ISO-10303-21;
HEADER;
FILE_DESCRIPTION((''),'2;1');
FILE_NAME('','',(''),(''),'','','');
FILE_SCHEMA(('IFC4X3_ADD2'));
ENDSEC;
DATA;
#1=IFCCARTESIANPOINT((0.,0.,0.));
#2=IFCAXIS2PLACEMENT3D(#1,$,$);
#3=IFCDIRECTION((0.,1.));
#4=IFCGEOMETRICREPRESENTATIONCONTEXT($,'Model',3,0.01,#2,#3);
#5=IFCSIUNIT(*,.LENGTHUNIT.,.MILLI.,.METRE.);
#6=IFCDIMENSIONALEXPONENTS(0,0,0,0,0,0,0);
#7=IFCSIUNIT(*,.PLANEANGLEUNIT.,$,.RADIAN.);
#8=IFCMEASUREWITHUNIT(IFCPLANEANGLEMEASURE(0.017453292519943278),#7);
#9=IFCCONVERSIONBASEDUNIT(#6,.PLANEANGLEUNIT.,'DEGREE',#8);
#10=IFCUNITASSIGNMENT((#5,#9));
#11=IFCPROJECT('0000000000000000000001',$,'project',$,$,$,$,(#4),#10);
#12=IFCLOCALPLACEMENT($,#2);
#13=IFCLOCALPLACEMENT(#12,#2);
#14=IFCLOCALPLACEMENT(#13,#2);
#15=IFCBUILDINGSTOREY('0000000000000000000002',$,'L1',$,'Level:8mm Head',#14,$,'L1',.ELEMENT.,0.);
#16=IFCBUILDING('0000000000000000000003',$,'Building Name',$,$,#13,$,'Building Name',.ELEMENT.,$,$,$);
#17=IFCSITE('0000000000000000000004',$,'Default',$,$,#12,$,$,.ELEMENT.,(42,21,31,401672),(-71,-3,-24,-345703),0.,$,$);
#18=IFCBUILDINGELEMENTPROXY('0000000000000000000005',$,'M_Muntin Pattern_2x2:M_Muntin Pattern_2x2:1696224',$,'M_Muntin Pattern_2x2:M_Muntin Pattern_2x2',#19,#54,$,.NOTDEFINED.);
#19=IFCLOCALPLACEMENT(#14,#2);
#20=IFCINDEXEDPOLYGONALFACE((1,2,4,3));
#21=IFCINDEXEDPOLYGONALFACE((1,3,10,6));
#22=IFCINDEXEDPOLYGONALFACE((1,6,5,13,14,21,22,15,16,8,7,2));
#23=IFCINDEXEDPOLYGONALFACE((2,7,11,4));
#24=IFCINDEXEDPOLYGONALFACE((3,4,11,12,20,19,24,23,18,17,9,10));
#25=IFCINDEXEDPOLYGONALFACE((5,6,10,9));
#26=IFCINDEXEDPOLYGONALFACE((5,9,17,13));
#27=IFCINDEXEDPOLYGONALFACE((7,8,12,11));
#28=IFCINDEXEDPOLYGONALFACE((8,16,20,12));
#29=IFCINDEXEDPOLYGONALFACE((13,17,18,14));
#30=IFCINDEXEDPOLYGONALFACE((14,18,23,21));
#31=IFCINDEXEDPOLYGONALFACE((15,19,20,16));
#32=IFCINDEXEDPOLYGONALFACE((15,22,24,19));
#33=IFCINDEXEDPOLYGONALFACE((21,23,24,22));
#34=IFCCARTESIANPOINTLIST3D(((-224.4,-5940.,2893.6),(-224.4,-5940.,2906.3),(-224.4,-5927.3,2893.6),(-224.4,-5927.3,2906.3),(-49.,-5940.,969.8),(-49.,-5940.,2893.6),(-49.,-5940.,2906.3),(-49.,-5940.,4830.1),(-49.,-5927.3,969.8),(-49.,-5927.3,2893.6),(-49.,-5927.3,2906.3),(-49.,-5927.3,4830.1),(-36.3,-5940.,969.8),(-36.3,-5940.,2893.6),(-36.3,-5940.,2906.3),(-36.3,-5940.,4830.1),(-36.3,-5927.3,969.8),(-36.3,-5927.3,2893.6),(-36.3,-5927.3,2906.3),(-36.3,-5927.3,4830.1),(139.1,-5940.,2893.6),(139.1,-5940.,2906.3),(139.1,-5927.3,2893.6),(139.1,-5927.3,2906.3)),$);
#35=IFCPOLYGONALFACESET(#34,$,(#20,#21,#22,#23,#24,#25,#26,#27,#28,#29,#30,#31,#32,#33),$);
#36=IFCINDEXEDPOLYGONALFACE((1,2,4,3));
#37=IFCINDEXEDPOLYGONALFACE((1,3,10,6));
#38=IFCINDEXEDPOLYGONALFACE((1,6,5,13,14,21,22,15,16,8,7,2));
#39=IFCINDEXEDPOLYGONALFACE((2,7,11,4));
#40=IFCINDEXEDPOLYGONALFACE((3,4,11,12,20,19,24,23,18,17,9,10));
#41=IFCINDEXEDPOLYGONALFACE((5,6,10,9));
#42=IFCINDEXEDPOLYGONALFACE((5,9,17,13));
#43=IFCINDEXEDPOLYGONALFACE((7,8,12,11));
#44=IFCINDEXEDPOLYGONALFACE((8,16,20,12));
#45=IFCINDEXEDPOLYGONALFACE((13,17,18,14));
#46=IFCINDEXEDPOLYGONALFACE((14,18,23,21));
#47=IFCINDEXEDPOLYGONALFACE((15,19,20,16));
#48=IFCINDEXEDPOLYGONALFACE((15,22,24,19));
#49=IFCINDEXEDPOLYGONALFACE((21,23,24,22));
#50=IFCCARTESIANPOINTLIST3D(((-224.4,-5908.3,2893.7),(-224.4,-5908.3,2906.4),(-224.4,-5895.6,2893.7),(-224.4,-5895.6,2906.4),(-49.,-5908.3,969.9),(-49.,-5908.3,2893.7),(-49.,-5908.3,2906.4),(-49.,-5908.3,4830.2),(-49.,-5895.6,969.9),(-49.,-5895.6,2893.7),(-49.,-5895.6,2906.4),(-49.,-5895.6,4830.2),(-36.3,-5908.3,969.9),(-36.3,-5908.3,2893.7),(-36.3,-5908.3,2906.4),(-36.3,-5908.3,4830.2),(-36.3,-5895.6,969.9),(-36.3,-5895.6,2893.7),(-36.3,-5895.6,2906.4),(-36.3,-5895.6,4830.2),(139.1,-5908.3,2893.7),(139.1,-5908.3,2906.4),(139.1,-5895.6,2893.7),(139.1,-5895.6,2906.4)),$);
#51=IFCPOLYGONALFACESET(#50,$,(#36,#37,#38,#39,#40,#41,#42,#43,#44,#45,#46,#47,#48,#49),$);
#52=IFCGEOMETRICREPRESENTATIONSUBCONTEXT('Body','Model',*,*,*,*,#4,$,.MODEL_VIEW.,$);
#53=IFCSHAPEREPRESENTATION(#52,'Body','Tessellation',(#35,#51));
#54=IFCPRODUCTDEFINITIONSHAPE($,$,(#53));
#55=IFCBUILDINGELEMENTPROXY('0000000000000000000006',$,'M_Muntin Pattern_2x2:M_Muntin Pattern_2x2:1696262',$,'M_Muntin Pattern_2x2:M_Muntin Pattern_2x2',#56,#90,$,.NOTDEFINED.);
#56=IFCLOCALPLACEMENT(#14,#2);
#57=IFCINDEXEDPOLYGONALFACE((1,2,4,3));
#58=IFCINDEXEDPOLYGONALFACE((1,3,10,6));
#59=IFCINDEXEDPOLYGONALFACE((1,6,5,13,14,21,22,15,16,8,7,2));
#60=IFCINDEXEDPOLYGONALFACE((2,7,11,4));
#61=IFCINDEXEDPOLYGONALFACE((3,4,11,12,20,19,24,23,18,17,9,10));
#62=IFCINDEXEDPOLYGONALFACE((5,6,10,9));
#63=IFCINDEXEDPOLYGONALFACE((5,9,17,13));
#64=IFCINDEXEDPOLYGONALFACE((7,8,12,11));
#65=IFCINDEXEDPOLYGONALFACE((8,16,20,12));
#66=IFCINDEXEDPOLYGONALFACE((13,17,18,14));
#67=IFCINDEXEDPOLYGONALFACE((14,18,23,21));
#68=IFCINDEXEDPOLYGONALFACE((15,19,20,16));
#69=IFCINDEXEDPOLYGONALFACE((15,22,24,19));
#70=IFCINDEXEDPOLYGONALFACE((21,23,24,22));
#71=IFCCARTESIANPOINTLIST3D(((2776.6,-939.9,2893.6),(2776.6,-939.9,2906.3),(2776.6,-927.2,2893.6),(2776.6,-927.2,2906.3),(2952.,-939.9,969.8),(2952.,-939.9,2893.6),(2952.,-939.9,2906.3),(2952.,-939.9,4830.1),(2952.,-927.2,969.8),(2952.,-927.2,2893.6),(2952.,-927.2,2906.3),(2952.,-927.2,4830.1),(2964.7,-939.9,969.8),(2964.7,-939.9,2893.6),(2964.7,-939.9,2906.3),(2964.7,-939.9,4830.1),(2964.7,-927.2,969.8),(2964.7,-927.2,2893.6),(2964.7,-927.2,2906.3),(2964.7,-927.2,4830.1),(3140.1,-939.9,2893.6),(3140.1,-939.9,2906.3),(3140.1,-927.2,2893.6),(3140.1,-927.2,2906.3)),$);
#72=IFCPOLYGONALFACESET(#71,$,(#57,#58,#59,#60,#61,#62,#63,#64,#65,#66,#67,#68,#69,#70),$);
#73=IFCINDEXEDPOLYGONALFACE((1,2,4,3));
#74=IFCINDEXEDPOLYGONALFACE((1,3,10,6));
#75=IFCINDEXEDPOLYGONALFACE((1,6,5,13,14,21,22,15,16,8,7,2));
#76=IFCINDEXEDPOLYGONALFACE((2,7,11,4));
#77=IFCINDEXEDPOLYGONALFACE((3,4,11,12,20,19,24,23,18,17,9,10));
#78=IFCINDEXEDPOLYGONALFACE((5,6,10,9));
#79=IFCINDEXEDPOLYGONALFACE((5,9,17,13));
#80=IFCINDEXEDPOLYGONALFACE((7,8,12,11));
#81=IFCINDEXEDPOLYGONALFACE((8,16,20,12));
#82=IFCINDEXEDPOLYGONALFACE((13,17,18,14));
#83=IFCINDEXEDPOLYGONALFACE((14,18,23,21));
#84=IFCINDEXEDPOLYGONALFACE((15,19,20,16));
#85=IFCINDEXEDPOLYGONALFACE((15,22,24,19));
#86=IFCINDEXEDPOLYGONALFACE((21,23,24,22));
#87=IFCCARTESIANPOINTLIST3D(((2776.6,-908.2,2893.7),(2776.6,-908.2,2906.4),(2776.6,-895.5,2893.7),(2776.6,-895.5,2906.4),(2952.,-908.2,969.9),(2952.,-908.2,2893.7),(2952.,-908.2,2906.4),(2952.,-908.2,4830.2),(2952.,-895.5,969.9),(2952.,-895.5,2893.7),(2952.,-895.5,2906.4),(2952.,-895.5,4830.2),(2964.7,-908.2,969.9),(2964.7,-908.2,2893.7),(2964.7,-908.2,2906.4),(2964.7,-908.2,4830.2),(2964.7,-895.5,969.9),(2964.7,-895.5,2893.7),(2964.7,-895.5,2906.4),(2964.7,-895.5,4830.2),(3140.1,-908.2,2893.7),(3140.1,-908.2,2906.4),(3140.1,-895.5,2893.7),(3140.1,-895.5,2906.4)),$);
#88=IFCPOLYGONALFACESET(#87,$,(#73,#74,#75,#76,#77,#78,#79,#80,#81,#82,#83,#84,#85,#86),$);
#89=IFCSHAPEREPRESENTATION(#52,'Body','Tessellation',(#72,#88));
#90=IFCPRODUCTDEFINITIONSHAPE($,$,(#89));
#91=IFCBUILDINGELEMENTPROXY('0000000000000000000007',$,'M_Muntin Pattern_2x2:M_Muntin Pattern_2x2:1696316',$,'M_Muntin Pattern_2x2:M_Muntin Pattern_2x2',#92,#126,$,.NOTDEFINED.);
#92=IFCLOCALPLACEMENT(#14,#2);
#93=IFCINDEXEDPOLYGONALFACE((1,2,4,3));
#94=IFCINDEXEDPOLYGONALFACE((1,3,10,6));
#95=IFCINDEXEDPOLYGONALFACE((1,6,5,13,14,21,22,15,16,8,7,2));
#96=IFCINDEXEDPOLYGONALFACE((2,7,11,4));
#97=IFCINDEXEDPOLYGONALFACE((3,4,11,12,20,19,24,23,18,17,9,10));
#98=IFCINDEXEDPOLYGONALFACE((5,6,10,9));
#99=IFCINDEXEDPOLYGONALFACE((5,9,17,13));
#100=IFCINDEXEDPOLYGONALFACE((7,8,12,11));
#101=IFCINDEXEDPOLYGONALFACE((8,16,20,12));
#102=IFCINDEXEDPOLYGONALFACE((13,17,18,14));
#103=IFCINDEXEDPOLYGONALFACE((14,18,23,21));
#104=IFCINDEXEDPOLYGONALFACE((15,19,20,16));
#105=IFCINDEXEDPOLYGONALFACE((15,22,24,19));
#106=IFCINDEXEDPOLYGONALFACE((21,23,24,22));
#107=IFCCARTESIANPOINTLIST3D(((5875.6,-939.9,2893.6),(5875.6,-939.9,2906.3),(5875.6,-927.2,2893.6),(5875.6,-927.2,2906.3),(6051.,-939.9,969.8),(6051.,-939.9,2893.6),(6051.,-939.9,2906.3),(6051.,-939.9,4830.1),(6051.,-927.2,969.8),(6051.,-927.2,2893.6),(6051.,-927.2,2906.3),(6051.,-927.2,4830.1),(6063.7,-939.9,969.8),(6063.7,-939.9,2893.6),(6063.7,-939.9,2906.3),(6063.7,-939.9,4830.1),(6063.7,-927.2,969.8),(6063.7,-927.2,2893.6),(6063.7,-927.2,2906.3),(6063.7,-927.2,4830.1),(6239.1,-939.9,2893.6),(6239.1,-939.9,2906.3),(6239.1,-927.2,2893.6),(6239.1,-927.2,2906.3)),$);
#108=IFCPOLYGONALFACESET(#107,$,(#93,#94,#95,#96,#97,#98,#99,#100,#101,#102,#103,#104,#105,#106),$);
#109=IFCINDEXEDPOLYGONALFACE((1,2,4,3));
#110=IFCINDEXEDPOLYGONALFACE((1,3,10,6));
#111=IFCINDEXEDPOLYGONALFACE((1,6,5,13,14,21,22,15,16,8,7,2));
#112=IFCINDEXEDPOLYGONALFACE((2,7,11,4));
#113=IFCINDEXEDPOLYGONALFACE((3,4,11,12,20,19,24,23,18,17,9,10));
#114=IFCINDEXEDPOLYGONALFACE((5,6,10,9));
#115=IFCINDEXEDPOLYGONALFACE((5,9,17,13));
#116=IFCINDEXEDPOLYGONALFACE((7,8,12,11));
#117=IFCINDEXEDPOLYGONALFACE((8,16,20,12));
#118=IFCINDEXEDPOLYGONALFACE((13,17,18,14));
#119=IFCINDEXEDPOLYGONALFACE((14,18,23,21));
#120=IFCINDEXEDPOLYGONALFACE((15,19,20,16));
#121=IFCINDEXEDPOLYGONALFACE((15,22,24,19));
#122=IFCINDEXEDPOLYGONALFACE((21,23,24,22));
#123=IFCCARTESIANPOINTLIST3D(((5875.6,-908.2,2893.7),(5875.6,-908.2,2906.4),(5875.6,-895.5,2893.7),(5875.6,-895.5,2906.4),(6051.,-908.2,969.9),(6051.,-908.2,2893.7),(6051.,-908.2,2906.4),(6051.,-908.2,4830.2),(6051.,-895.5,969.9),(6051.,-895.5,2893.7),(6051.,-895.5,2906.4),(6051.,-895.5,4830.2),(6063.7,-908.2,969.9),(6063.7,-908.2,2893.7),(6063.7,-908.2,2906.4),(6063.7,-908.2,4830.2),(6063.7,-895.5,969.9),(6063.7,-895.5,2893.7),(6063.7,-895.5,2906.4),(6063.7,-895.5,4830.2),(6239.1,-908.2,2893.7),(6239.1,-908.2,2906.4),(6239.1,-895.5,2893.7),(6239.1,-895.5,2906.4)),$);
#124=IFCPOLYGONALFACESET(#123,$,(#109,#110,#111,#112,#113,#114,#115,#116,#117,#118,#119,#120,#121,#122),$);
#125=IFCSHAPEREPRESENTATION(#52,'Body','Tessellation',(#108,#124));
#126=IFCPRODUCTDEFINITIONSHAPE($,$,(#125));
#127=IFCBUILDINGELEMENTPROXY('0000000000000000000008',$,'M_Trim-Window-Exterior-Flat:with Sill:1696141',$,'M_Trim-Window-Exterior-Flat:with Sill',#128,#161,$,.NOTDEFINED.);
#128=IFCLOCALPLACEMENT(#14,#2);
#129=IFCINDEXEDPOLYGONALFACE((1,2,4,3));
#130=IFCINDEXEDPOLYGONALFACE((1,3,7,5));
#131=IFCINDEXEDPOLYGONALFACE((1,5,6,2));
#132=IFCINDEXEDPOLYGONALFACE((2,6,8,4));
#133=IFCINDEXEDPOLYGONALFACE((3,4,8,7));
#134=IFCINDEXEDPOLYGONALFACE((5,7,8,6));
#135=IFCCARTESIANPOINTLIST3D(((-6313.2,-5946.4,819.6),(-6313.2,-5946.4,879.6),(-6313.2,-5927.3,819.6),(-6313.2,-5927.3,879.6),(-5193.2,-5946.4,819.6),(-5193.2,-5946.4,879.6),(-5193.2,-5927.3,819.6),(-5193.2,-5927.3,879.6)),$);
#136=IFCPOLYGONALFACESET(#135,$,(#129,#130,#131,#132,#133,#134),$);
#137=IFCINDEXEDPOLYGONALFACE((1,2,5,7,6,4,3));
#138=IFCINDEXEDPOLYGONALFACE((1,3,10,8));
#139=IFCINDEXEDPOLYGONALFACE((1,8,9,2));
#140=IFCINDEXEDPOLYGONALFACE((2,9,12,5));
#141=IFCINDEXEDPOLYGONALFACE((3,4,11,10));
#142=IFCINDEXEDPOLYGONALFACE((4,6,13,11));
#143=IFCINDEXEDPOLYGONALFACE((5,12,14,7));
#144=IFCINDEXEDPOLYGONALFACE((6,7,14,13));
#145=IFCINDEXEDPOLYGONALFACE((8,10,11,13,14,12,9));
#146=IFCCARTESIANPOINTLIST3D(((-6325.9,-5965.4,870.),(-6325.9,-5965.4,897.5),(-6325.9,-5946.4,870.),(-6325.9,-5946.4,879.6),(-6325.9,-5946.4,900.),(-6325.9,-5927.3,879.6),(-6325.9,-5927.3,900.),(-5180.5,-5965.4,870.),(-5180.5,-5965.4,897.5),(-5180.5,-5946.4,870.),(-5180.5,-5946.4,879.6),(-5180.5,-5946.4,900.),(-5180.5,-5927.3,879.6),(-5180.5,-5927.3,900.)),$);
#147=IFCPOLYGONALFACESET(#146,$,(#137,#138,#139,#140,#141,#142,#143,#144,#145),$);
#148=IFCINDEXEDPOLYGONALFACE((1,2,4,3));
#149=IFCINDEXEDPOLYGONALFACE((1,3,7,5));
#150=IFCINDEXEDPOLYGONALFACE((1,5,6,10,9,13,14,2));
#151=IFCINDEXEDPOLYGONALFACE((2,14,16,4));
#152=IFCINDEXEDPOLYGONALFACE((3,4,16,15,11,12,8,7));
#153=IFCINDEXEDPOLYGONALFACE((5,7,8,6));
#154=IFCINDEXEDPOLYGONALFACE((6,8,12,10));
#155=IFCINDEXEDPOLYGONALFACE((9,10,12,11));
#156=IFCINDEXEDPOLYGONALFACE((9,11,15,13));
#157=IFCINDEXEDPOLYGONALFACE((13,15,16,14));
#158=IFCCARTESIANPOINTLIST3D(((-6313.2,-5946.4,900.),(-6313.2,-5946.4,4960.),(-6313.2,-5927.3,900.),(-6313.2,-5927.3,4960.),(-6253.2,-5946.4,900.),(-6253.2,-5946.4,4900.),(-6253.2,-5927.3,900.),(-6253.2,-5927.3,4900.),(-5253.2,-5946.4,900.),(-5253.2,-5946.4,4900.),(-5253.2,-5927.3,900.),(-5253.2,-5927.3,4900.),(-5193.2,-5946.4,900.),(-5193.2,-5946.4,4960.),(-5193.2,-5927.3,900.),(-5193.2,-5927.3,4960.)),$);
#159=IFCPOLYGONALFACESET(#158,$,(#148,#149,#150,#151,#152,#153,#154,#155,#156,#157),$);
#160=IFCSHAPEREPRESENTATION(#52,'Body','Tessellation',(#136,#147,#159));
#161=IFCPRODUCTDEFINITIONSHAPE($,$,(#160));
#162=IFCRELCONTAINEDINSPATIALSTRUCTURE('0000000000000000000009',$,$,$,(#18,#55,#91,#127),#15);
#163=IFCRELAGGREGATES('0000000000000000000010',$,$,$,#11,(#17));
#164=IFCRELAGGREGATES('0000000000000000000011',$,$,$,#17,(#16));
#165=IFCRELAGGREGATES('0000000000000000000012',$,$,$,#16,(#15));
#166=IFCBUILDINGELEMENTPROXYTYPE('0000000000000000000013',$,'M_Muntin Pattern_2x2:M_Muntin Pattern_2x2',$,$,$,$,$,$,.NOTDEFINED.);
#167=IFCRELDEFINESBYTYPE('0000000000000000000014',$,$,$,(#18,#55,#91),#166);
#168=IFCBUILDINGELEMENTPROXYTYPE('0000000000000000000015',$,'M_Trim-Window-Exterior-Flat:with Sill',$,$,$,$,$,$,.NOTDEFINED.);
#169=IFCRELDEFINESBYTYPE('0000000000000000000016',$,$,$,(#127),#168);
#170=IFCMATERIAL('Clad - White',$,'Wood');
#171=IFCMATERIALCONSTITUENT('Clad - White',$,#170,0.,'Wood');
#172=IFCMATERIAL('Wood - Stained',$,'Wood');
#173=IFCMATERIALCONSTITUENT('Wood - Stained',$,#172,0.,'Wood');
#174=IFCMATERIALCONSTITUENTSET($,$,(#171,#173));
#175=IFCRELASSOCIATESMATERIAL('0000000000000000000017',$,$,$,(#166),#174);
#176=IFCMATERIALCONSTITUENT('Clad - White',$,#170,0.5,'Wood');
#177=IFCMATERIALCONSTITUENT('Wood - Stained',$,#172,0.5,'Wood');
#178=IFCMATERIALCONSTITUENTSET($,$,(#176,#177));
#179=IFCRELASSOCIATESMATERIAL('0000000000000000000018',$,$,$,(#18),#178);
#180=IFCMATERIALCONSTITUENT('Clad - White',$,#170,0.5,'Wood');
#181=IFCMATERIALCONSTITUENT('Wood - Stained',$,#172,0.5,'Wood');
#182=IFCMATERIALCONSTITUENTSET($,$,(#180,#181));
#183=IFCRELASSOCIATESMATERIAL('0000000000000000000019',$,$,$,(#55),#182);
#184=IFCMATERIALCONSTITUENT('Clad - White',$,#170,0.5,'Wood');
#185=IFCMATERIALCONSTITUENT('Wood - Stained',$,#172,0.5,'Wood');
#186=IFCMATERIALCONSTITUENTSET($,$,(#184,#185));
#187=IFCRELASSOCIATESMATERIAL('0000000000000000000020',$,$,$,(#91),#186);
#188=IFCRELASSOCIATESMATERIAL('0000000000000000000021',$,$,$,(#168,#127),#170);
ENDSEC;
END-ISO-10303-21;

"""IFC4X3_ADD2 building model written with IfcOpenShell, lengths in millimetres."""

from ifc_helpers import new_model, entity, si_unit, converted_unit, direction, frame, frame_2d, origin, place, context, subcontext, project, spatial, polyline, rectangle, outline, extrude, source, transform, mapped, material, constituent, constituent_set, type_object, type_shapes, element, save


model = new_model("IFC4X3_ADD2")

# Units and contexts
model_context = context("Model", 3, precision=0.01, world=origin(), true_north=direction((0.0, 1.0)))
body_context = subcontext(model_context, "Body", "Model", "MODEL_VIEW")
ifc_project = project(units=[si_unit("LENGTHUNIT", "METRE", prefix="MILLI"), converted_unit("PLANEANGLEUNIT", "DEGREE", entity("IfcPlaneAngleMeasure", 0.017453292519943278), si_unit("PLANEANGLEUNIT", "RADIAN"), dimensions=[0, 0, 0, 0, 0, 0, 0])], contexts=[model_context])

# Site, building, storey
site_placement = place(None, origin())
site = spatial("IfcSite", under=ifc_project, at=site_placement, Name="Default", CompositionType="ELEMENT", RefLatitude=(42, 21, 31, 401672), RefLongitude=(-71, -3, -24, -345703), RefElevation=0.0)
building_placement = place(site_placement, origin())
building = spatial("IfcBuilding", under=site, at=building_placement, Name="Building Name", LongName="Building Name", CompositionType="ELEMENT")
storey_placement = place(building_placement, origin())
storey = spatial("IfcBuildingStorey", under=building, at=storey_placement, Name="L1", ObjectType="Level:8mm Head", LongName="L1", CompositionType="ELEMENT", Elevation=0.0)

# Building element proxies
ifc_material_1 = material(Name="Clad - White", Category="Wood")
ifc_material_2 = material(Name="Wood - Stained", Category="Wood")
ifc_constituent_1 = constituent(ifc_material_1, Name="Clad - White", Category="Wood", fraction=0.0)
ifc_constituent_2 = constituent(ifc_material_2, Name="Wood - Stained", Category="Wood", fraction=0.0)
ifc_constituent_set_1 = constituent_set(constituents=[ifc_constituent_1, ifc_constituent_2])
building_element_proxy_type_1 = type_object("IfcBuildingElementProxyType", Name="M_Muntin Pattern_2x2:M_Muntin Pattern_2x2", PredefinedType="NOTDEFINED", material=ifc_constituent_set_1)
shared_shape_1 = source(origin(), body_context, "Body", "SweptSolid", [
    extrude(outline(polyline([(6.4, -6.4), (1930.1, -6.4), (1930.1, 6.3), (6.4, 6.3), (6.4, 181.7), (-6.3, 181.7), (-6.3, 6.3), (-1930.2, 6.3), (-1930.2, -6.4), (-6.3, -6.4), (-6.3, -181.7), (6.4, -181.7), (6.4, -6.4)])), frame((0.0, -22.2, 1930.1), z_axis=(0.0, 1.0, 0.0), x_axis=(0.0, 0.0, 1.0)), (0.0, 0.0, 1.0), 12.7),
    extrude(outline(polyline([(6.4, -6.4), (1930.2, -6.4), (1930.2, 6.3), (6.4, 6.3), (6.4, 181.7), (-6.3, 181.7), (-6.3, 6.3), (-1930.2, 6.3), (-1930.2, -6.4), (-6.3, -6.4), (-6.3, -181.7), (6.4, -181.7), (6.4, -6.4)])), frame((0.0, 9.5, 1930.2), z_axis=(0.0, 1.0, 0.0), x_axis=(0.0, 0.0, 1.0)), (0.0, 0.0, 1.0), 12.7),
])
type_shapes(building_element_proxy_type_1, [shared_shape_1])
ifc_constituent_3 = constituent(ifc_material_1, Name="Clad - White", Category="Wood", fraction=0.5)
ifc_constituent_4 = constituent(ifc_material_2, Name="Wood - Stained", Category="Wood", fraction=0.5)
ifc_constituent_set_2 = constituent_set(constituents=[ifc_constituent_3, ifc_constituent_4])
proxy_1_placement = place(storey_placement, frame((-42.6, -5917.8, 969.9)))
element("IfcBuildingElementProxy", 1, at=proxy_1_placement, inside=storey, type_object=building_element_proxy_type_1, material=ifc_constituent_set_2, Name="M_Muntin Pattern_2x2:M_Muntin Pattern_2x2:1696224", ObjectType="M_Muntin Pattern_2x2:M_Muntin Pattern_2x2", PredefinedType="NOTDEFINED", context=body_context, shape_type="MappedRepresentation", body=[
    mapped(shared_shape_1, transform((0.0, 0.0, 0.0), scale=1.0)),
])
ifc_constituent_5 = constituent(ifc_material_1, Name="Clad - White", Category="Wood", fraction=0.5)
ifc_constituent_6 = constituent(ifc_material_2, Name="Wood - Stained", Category="Wood", fraction=0.5)
ifc_constituent_set_3 = constituent_set(constituents=[ifc_constituent_5, ifc_constituent_6])
proxy_2_placement = place(storey_placement, frame((2958.4, -917.7, 969.9)))
element("IfcBuildingElementProxy", 2, at=proxy_2_placement, inside=storey, type_object=building_element_proxy_type_1, material=ifc_constituent_set_3, Name="M_Muntin Pattern_2x2:M_Muntin Pattern_2x2:1696262", ObjectType="M_Muntin Pattern_2x2:M_Muntin Pattern_2x2", PredefinedType="NOTDEFINED", context=body_context, shape_type="MappedRepresentation", body=[
    mapped(shared_shape_1, transform((0.0, 0.0, 0.0), scale=1.0)),
])
ifc_constituent_7 = constituent(ifc_material_1, Name="Clad - White", Category="Wood", fraction=0.5)
ifc_constituent_8 = constituent(ifc_material_2, Name="Wood - Stained", Category="Wood", fraction=0.5)
ifc_constituent_set_4 = constituent_set(constituents=[ifc_constituent_7, ifc_constituent_8])
proxy_3_placement = place(storey_placement, frame((6057.4, -917.7, 969.9)))
element("IfcBuildingElementProxy", 3, at=proxy_3_placement, inside=storey, type_object=building_element_proxy_type_1, material=ifc_constituent_set_4, Name="M_Muntin Pattern_2x2:M_Muntin Pattern_2x2:1696316", ObjectType="M_Muntin Pattern_2x2:M_Muntin Pattern_2x2", PredefinedType="NOTDEFINED", context=body_context, shape_type="MappedRepresentation", body=[
    mapped(shared_shape_1, transform((0.0, 0.0, 0.0), scale=1.0)),
])
building_element_proxy_type_2 = type_object("IfcBuildingElementProxyType", Name="M_Trim-Window-Exterior-Flat:with Sill", PredefinedType="NOTDEFINED", material=ifc_material_1)
shared_shape_2 = source(origin(), body_context, "Body", "SweptSolid", [
    extrude(rectangle(XDim=1120.0, YDim=60.0, at=frame_2d((0.0, 0.0), x_axis=(1.0, 0.0))), frame((0.0, -4050.4, 0.0), z_axis=(0.0, 0.0, 1.0), x_axis=(-1.0, 0.0, 0.0)), (0.0, 0.0, 1.0), 19.0),
    extrude(outline(polyline([(-19.0, -15.2), (0.0, -15.2), (0.0, -5.7), (19.0, -5.7), (19.0, 14.8), (0.0, 14.8), (-19.0, 12.3), (-19.0, -15.2)])), frame((-572.7, -4014.8, 19.0), z_axis=(1.0, 0.0, 0.0), x_axis=(0.0, 0.0, -1.0)), (0.0, 0.0, 1.0), 1145.4),
    extrude(outline(polyline([(-2045.0, -560.0), (2015.0, -560.0), (2015.0, -500.0), (-1985.0, -500.0), (-1985.0, 500.0), (2015.0, 500.0), (2015.0, 560.0), (-2045.0, 560.0), (-2045.0, -560.0)])), frame((0.0, -1985.0, 0.0), z_axis=(0.0, 0.0, 1.0), x_axis=(0.0, -1.0, 0.0)), (0.0, 0.0, 1.0), 19.0),
])
type_shapes(building_element_proxy_type_2, [shared_shape_2])
for number, where, z_axis, x_axis, name in (
    (4, (-5753.2, -5927.3, 4900.0), (0.0, -1.0, 0.0), (1.0, 0.0, 0.0), "M_Trim-Window-Exterior-Flat:with Sill:1696141"),
):
    element("IfcBuildingElementProxy", number, at=place(storey_placement, frame(where, z_axis=z_axis, x_axis=x_axis)), inside=storey, type_object=building_element_proxy_type_2, material=ifc_material_1, Name=name, ObjectType="M_Trim-Window-Exterior-Flat:with Sill", PredefinedType="NOTDEFINED", context=body_context, shape_type="MappedRepresentation", body=[
        mapped(shared_shape_2, transform((0.0, 0.0, 0.0), scale=1.0)),
    ])

save(model, "model.ifc")
